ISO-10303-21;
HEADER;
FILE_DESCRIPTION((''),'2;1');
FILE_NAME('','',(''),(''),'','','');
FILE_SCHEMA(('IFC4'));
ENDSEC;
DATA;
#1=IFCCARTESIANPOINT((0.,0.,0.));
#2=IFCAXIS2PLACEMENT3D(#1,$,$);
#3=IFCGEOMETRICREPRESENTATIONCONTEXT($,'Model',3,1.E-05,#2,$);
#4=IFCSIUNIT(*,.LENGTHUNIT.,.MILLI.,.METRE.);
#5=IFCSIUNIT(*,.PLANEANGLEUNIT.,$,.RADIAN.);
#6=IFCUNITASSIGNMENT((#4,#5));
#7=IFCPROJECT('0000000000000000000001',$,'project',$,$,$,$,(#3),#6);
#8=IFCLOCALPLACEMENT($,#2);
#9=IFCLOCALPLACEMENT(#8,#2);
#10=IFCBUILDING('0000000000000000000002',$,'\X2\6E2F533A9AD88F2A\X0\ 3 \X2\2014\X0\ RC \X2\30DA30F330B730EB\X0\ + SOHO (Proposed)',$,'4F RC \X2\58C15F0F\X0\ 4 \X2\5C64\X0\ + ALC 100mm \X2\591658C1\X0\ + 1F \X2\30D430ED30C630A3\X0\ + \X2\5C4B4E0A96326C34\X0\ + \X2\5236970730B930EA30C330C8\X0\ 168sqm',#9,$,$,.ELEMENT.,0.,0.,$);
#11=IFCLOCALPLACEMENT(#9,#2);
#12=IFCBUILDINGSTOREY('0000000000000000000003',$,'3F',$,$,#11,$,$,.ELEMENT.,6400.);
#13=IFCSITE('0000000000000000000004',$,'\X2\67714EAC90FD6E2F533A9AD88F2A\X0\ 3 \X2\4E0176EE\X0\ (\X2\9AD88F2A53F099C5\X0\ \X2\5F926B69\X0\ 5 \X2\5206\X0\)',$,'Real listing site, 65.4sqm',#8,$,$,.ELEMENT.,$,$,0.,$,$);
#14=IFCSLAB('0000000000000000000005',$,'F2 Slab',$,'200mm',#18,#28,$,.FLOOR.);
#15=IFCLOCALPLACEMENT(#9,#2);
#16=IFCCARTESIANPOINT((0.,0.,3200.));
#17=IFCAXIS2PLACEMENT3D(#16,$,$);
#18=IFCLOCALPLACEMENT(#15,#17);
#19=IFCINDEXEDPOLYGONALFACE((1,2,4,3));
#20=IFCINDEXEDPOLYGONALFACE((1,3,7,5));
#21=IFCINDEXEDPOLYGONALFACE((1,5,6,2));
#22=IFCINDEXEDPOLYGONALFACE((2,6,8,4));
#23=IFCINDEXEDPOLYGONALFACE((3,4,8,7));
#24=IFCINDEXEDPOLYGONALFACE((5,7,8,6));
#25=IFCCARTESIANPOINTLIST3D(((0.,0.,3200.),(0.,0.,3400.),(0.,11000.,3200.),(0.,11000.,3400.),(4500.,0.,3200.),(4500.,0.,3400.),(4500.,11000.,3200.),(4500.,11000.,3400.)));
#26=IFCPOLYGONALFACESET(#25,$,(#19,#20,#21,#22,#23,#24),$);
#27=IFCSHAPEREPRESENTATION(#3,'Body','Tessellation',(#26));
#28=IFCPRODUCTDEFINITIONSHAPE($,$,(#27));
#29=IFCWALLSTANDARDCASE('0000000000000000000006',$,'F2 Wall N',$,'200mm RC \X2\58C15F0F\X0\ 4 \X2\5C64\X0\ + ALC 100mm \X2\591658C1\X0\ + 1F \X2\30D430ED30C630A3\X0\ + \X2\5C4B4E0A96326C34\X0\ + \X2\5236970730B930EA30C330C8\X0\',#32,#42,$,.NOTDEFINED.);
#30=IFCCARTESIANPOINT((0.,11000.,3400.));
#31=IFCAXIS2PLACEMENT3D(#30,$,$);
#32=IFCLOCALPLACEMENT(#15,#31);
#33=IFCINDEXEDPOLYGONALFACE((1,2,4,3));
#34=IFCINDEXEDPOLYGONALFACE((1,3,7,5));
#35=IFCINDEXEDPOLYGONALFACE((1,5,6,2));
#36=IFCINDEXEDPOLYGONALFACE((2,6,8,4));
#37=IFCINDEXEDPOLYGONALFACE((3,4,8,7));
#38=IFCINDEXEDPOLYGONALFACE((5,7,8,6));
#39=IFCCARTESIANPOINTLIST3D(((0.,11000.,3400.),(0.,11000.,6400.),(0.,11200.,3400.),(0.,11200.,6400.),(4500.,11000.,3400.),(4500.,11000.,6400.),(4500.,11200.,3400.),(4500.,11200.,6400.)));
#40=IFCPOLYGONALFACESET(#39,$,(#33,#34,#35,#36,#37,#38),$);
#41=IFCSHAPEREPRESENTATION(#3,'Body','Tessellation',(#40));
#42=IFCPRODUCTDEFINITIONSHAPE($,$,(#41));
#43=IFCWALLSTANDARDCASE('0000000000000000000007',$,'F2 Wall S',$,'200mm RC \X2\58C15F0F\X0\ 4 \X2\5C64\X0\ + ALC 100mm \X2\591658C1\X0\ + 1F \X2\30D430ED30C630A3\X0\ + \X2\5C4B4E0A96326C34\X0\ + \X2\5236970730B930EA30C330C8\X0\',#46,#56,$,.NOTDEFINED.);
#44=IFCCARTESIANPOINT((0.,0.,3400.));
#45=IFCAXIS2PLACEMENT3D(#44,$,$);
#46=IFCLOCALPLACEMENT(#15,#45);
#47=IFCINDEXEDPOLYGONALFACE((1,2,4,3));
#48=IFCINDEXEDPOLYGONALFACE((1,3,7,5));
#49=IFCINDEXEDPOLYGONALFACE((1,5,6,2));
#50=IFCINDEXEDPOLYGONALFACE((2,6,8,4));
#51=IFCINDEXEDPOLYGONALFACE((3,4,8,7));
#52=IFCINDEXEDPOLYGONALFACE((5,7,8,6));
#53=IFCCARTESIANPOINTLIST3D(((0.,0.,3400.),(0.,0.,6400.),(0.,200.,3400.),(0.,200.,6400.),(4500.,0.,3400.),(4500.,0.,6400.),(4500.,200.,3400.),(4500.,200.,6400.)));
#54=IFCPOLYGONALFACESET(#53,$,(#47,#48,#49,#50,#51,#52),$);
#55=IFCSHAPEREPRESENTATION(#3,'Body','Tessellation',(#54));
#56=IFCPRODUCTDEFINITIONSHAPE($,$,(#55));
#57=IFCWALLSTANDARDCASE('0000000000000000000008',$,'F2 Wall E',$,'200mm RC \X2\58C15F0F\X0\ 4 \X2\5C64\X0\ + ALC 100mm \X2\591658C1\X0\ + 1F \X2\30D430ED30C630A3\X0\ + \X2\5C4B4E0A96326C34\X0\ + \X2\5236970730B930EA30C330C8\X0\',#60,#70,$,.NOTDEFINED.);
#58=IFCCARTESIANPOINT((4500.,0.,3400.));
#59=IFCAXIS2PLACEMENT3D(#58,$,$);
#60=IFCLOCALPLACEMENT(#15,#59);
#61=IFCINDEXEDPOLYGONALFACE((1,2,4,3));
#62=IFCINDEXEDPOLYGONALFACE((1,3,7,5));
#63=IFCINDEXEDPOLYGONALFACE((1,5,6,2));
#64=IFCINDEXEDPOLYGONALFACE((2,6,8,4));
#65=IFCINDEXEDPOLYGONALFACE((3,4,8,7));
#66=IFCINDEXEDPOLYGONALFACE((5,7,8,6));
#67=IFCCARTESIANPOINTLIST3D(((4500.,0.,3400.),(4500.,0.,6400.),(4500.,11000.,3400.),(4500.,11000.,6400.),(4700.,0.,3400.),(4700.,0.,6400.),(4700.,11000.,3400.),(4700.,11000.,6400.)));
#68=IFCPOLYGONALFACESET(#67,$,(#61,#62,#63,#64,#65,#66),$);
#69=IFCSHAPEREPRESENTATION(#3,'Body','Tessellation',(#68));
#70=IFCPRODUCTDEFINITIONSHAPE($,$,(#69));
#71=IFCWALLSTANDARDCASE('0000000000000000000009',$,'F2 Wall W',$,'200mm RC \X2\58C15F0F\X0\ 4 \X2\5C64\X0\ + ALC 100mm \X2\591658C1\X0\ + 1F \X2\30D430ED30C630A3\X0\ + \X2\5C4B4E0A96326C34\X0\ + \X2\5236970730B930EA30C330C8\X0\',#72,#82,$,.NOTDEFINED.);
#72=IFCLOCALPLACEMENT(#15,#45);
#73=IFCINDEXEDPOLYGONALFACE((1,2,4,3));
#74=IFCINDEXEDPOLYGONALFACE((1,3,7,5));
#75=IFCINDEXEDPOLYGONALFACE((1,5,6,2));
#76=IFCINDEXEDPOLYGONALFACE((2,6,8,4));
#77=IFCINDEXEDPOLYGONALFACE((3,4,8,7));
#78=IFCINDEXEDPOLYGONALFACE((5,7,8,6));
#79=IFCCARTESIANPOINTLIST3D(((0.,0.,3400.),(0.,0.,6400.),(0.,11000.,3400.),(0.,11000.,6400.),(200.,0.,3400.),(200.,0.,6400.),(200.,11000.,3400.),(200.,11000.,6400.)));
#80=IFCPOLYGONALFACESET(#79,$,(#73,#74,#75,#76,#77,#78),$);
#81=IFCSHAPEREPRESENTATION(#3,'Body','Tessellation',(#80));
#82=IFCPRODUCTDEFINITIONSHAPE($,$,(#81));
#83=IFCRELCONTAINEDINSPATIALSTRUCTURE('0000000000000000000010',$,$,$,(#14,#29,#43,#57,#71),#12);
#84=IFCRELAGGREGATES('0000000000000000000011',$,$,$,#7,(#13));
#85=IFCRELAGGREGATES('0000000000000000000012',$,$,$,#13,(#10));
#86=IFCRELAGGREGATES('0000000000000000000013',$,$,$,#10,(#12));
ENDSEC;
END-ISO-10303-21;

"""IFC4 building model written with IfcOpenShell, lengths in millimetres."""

from ifc_helpers import new_model, si_unit, frame, frame_2d, origin, place, context, project, spatial, rectangle, extrude, element, save


model = new_model("IFC4")

# Units and contexts
model_context = context("Model", 3, precision=1e-05, world=origin())
ifc_project = project(units=[si_unit("LENGTHUNIT", "METRE", prefix="MILLI"), si_unit("PLANEANGLEUNIT", "RADIAN")], contexts=[model_context])

# Site, building, storey
site_placement = place(None, origin())
site = spatial("IfcSite", under=ifc_project, at=site_placement, Name="東京都港区高輪 3 丁目 (高輪台駅 徒歩 5 分)", ObjectType="Real listing site, 65.4sqm", CompositionType="ELEMENT", RefElevation=0.0)
building_placement = place(site_placement, origin())
building = spatial("IfcBuilding", under=site, at=building_placement, Name="港区高輪 3 — RC ペンシル + SOHO (Proposed)", ObjectType="4F RC 壁式 4 層 + ALC 100mm 外壁 + 1F ピロティ + 屋上防水 + 制震スリット 168sqm", CompositionType="ELEMENT", ElevationOfRefHeight=0.0, ElevationOfTerrain=0.0)
storey_placement = place(building_placement, origin())
storey = spatial("IfcBuildingStorey", under=building, at=storey_placement, Name="3F", CompositionType="ELEMENT", Elevation=6400.0)

# Slab
placement = place(building_placement, origin())
slab_placement = place(placement, frame((0.0, 0.0, 3200.0)))
element("IfcSlab", 1, at=slab_placement, inside=storey, Name="F2 Slab", ObjectType="200mm", PredefinedType="FLOOR", context=model_context, shape_type="SweptSolid", body=[
    extrude(rectangle(XDim=4500.0, YDim=11000.0, at=frame_2d((2250.0, 5500.0))), frame((0.0, 0.0, 3200.0)), (0.0, 0.0, 1.0), 200.0),
])

# Walls
wall_1_placement = place(placement, frame((0.0, 11000.0, 3400.0)))
element("IfcWallStandardCase", 2, at=wall_1_placement, inside=storey, Name="F2 Wall N", ObjectType="200mm RC 壁式 4 層 + ALC 100mm 外壁 + 1F ピロティ + 屋上防水 + 制震スリット", PredefinedType="NOTDEFINED", context=model_context, shape_type="SweptSolid", body=[
    extrude(rectangle(XDim=4500.0, YDim=200.0, at=frame_2d((2250.0, 100.0))), frame((0.0, 11000.0, 3400.0)), (0.0, 0.0, 1.0), 3000.0),
])
wall_2_placement = place(placement, frame((0.0, 0.0, 3400.0)))
element("IfcWallStandardCase", 3, at=wall_2_placement, inside=storey, Name="F2 Wall S", ObjectType="200mm RC 壁式 4 層 + ALC 100mm 外壁 + 1F ピロティ + 屋上防水 + 制震スリット", PredefinedType="NOTDEFINED", context=model_context, shape_type="SweptSolid", body=[
    extrude(rectangle(XDim=4500.0, YDim=200.0, at=frame_2d((2250.0, 100.0))), frame((0.0, 0.0, 3400.0)), (0.0, 0.0, 1.0), 3000.0),
])
wall_3_placement = place(placement, frame((4500.0, 0.0, 3400.0)))
element("IfcWallStandardCase", 4, at=wall_3_placement, inside=storey, Name="F2 Wall E", ObjectType="200mm RC 壁式 4 層 + ALC 100mm 外壁 + 1F ピロティ + 屋上防水 + 制震スリット", PredefinedType="NOTDEFINED", context=model_context, shape_type="SweptSolid", body=[
    extrude(rectangle(XDim=200.0, YDim=11000.0, at=frame_2d((100.0, 5500.0))), frame((4500.0, 0.0, 3400.0)), (0.0, 0.0, 1.0), 3000.0),
])
wall_4_placement = place(placement, frame((0.0, 0.0, 3400.0)))
element("IfcWallStandardCase", 5, at=wall_4_placement, inside=storey, Name="F2 Wall W", ObjectType="200mm RC 壁式 4 層 + ALC 100mm 外壁 + 1F ピロティ + 屋上防水 + 制震スリット", PredefinedType="NOTDEFINED", context=model_context, shape_type="SweptSolid", body=[
    extrude(rectangle(XDim=200.0, YDim=11000.0, at=frame_2d((100.0, 5500.0))), frame((0.0, 0.0, 3400.0)), (0.0, 0.0, 1.0), 3000.0),
])

save(model, "model.ifc")
